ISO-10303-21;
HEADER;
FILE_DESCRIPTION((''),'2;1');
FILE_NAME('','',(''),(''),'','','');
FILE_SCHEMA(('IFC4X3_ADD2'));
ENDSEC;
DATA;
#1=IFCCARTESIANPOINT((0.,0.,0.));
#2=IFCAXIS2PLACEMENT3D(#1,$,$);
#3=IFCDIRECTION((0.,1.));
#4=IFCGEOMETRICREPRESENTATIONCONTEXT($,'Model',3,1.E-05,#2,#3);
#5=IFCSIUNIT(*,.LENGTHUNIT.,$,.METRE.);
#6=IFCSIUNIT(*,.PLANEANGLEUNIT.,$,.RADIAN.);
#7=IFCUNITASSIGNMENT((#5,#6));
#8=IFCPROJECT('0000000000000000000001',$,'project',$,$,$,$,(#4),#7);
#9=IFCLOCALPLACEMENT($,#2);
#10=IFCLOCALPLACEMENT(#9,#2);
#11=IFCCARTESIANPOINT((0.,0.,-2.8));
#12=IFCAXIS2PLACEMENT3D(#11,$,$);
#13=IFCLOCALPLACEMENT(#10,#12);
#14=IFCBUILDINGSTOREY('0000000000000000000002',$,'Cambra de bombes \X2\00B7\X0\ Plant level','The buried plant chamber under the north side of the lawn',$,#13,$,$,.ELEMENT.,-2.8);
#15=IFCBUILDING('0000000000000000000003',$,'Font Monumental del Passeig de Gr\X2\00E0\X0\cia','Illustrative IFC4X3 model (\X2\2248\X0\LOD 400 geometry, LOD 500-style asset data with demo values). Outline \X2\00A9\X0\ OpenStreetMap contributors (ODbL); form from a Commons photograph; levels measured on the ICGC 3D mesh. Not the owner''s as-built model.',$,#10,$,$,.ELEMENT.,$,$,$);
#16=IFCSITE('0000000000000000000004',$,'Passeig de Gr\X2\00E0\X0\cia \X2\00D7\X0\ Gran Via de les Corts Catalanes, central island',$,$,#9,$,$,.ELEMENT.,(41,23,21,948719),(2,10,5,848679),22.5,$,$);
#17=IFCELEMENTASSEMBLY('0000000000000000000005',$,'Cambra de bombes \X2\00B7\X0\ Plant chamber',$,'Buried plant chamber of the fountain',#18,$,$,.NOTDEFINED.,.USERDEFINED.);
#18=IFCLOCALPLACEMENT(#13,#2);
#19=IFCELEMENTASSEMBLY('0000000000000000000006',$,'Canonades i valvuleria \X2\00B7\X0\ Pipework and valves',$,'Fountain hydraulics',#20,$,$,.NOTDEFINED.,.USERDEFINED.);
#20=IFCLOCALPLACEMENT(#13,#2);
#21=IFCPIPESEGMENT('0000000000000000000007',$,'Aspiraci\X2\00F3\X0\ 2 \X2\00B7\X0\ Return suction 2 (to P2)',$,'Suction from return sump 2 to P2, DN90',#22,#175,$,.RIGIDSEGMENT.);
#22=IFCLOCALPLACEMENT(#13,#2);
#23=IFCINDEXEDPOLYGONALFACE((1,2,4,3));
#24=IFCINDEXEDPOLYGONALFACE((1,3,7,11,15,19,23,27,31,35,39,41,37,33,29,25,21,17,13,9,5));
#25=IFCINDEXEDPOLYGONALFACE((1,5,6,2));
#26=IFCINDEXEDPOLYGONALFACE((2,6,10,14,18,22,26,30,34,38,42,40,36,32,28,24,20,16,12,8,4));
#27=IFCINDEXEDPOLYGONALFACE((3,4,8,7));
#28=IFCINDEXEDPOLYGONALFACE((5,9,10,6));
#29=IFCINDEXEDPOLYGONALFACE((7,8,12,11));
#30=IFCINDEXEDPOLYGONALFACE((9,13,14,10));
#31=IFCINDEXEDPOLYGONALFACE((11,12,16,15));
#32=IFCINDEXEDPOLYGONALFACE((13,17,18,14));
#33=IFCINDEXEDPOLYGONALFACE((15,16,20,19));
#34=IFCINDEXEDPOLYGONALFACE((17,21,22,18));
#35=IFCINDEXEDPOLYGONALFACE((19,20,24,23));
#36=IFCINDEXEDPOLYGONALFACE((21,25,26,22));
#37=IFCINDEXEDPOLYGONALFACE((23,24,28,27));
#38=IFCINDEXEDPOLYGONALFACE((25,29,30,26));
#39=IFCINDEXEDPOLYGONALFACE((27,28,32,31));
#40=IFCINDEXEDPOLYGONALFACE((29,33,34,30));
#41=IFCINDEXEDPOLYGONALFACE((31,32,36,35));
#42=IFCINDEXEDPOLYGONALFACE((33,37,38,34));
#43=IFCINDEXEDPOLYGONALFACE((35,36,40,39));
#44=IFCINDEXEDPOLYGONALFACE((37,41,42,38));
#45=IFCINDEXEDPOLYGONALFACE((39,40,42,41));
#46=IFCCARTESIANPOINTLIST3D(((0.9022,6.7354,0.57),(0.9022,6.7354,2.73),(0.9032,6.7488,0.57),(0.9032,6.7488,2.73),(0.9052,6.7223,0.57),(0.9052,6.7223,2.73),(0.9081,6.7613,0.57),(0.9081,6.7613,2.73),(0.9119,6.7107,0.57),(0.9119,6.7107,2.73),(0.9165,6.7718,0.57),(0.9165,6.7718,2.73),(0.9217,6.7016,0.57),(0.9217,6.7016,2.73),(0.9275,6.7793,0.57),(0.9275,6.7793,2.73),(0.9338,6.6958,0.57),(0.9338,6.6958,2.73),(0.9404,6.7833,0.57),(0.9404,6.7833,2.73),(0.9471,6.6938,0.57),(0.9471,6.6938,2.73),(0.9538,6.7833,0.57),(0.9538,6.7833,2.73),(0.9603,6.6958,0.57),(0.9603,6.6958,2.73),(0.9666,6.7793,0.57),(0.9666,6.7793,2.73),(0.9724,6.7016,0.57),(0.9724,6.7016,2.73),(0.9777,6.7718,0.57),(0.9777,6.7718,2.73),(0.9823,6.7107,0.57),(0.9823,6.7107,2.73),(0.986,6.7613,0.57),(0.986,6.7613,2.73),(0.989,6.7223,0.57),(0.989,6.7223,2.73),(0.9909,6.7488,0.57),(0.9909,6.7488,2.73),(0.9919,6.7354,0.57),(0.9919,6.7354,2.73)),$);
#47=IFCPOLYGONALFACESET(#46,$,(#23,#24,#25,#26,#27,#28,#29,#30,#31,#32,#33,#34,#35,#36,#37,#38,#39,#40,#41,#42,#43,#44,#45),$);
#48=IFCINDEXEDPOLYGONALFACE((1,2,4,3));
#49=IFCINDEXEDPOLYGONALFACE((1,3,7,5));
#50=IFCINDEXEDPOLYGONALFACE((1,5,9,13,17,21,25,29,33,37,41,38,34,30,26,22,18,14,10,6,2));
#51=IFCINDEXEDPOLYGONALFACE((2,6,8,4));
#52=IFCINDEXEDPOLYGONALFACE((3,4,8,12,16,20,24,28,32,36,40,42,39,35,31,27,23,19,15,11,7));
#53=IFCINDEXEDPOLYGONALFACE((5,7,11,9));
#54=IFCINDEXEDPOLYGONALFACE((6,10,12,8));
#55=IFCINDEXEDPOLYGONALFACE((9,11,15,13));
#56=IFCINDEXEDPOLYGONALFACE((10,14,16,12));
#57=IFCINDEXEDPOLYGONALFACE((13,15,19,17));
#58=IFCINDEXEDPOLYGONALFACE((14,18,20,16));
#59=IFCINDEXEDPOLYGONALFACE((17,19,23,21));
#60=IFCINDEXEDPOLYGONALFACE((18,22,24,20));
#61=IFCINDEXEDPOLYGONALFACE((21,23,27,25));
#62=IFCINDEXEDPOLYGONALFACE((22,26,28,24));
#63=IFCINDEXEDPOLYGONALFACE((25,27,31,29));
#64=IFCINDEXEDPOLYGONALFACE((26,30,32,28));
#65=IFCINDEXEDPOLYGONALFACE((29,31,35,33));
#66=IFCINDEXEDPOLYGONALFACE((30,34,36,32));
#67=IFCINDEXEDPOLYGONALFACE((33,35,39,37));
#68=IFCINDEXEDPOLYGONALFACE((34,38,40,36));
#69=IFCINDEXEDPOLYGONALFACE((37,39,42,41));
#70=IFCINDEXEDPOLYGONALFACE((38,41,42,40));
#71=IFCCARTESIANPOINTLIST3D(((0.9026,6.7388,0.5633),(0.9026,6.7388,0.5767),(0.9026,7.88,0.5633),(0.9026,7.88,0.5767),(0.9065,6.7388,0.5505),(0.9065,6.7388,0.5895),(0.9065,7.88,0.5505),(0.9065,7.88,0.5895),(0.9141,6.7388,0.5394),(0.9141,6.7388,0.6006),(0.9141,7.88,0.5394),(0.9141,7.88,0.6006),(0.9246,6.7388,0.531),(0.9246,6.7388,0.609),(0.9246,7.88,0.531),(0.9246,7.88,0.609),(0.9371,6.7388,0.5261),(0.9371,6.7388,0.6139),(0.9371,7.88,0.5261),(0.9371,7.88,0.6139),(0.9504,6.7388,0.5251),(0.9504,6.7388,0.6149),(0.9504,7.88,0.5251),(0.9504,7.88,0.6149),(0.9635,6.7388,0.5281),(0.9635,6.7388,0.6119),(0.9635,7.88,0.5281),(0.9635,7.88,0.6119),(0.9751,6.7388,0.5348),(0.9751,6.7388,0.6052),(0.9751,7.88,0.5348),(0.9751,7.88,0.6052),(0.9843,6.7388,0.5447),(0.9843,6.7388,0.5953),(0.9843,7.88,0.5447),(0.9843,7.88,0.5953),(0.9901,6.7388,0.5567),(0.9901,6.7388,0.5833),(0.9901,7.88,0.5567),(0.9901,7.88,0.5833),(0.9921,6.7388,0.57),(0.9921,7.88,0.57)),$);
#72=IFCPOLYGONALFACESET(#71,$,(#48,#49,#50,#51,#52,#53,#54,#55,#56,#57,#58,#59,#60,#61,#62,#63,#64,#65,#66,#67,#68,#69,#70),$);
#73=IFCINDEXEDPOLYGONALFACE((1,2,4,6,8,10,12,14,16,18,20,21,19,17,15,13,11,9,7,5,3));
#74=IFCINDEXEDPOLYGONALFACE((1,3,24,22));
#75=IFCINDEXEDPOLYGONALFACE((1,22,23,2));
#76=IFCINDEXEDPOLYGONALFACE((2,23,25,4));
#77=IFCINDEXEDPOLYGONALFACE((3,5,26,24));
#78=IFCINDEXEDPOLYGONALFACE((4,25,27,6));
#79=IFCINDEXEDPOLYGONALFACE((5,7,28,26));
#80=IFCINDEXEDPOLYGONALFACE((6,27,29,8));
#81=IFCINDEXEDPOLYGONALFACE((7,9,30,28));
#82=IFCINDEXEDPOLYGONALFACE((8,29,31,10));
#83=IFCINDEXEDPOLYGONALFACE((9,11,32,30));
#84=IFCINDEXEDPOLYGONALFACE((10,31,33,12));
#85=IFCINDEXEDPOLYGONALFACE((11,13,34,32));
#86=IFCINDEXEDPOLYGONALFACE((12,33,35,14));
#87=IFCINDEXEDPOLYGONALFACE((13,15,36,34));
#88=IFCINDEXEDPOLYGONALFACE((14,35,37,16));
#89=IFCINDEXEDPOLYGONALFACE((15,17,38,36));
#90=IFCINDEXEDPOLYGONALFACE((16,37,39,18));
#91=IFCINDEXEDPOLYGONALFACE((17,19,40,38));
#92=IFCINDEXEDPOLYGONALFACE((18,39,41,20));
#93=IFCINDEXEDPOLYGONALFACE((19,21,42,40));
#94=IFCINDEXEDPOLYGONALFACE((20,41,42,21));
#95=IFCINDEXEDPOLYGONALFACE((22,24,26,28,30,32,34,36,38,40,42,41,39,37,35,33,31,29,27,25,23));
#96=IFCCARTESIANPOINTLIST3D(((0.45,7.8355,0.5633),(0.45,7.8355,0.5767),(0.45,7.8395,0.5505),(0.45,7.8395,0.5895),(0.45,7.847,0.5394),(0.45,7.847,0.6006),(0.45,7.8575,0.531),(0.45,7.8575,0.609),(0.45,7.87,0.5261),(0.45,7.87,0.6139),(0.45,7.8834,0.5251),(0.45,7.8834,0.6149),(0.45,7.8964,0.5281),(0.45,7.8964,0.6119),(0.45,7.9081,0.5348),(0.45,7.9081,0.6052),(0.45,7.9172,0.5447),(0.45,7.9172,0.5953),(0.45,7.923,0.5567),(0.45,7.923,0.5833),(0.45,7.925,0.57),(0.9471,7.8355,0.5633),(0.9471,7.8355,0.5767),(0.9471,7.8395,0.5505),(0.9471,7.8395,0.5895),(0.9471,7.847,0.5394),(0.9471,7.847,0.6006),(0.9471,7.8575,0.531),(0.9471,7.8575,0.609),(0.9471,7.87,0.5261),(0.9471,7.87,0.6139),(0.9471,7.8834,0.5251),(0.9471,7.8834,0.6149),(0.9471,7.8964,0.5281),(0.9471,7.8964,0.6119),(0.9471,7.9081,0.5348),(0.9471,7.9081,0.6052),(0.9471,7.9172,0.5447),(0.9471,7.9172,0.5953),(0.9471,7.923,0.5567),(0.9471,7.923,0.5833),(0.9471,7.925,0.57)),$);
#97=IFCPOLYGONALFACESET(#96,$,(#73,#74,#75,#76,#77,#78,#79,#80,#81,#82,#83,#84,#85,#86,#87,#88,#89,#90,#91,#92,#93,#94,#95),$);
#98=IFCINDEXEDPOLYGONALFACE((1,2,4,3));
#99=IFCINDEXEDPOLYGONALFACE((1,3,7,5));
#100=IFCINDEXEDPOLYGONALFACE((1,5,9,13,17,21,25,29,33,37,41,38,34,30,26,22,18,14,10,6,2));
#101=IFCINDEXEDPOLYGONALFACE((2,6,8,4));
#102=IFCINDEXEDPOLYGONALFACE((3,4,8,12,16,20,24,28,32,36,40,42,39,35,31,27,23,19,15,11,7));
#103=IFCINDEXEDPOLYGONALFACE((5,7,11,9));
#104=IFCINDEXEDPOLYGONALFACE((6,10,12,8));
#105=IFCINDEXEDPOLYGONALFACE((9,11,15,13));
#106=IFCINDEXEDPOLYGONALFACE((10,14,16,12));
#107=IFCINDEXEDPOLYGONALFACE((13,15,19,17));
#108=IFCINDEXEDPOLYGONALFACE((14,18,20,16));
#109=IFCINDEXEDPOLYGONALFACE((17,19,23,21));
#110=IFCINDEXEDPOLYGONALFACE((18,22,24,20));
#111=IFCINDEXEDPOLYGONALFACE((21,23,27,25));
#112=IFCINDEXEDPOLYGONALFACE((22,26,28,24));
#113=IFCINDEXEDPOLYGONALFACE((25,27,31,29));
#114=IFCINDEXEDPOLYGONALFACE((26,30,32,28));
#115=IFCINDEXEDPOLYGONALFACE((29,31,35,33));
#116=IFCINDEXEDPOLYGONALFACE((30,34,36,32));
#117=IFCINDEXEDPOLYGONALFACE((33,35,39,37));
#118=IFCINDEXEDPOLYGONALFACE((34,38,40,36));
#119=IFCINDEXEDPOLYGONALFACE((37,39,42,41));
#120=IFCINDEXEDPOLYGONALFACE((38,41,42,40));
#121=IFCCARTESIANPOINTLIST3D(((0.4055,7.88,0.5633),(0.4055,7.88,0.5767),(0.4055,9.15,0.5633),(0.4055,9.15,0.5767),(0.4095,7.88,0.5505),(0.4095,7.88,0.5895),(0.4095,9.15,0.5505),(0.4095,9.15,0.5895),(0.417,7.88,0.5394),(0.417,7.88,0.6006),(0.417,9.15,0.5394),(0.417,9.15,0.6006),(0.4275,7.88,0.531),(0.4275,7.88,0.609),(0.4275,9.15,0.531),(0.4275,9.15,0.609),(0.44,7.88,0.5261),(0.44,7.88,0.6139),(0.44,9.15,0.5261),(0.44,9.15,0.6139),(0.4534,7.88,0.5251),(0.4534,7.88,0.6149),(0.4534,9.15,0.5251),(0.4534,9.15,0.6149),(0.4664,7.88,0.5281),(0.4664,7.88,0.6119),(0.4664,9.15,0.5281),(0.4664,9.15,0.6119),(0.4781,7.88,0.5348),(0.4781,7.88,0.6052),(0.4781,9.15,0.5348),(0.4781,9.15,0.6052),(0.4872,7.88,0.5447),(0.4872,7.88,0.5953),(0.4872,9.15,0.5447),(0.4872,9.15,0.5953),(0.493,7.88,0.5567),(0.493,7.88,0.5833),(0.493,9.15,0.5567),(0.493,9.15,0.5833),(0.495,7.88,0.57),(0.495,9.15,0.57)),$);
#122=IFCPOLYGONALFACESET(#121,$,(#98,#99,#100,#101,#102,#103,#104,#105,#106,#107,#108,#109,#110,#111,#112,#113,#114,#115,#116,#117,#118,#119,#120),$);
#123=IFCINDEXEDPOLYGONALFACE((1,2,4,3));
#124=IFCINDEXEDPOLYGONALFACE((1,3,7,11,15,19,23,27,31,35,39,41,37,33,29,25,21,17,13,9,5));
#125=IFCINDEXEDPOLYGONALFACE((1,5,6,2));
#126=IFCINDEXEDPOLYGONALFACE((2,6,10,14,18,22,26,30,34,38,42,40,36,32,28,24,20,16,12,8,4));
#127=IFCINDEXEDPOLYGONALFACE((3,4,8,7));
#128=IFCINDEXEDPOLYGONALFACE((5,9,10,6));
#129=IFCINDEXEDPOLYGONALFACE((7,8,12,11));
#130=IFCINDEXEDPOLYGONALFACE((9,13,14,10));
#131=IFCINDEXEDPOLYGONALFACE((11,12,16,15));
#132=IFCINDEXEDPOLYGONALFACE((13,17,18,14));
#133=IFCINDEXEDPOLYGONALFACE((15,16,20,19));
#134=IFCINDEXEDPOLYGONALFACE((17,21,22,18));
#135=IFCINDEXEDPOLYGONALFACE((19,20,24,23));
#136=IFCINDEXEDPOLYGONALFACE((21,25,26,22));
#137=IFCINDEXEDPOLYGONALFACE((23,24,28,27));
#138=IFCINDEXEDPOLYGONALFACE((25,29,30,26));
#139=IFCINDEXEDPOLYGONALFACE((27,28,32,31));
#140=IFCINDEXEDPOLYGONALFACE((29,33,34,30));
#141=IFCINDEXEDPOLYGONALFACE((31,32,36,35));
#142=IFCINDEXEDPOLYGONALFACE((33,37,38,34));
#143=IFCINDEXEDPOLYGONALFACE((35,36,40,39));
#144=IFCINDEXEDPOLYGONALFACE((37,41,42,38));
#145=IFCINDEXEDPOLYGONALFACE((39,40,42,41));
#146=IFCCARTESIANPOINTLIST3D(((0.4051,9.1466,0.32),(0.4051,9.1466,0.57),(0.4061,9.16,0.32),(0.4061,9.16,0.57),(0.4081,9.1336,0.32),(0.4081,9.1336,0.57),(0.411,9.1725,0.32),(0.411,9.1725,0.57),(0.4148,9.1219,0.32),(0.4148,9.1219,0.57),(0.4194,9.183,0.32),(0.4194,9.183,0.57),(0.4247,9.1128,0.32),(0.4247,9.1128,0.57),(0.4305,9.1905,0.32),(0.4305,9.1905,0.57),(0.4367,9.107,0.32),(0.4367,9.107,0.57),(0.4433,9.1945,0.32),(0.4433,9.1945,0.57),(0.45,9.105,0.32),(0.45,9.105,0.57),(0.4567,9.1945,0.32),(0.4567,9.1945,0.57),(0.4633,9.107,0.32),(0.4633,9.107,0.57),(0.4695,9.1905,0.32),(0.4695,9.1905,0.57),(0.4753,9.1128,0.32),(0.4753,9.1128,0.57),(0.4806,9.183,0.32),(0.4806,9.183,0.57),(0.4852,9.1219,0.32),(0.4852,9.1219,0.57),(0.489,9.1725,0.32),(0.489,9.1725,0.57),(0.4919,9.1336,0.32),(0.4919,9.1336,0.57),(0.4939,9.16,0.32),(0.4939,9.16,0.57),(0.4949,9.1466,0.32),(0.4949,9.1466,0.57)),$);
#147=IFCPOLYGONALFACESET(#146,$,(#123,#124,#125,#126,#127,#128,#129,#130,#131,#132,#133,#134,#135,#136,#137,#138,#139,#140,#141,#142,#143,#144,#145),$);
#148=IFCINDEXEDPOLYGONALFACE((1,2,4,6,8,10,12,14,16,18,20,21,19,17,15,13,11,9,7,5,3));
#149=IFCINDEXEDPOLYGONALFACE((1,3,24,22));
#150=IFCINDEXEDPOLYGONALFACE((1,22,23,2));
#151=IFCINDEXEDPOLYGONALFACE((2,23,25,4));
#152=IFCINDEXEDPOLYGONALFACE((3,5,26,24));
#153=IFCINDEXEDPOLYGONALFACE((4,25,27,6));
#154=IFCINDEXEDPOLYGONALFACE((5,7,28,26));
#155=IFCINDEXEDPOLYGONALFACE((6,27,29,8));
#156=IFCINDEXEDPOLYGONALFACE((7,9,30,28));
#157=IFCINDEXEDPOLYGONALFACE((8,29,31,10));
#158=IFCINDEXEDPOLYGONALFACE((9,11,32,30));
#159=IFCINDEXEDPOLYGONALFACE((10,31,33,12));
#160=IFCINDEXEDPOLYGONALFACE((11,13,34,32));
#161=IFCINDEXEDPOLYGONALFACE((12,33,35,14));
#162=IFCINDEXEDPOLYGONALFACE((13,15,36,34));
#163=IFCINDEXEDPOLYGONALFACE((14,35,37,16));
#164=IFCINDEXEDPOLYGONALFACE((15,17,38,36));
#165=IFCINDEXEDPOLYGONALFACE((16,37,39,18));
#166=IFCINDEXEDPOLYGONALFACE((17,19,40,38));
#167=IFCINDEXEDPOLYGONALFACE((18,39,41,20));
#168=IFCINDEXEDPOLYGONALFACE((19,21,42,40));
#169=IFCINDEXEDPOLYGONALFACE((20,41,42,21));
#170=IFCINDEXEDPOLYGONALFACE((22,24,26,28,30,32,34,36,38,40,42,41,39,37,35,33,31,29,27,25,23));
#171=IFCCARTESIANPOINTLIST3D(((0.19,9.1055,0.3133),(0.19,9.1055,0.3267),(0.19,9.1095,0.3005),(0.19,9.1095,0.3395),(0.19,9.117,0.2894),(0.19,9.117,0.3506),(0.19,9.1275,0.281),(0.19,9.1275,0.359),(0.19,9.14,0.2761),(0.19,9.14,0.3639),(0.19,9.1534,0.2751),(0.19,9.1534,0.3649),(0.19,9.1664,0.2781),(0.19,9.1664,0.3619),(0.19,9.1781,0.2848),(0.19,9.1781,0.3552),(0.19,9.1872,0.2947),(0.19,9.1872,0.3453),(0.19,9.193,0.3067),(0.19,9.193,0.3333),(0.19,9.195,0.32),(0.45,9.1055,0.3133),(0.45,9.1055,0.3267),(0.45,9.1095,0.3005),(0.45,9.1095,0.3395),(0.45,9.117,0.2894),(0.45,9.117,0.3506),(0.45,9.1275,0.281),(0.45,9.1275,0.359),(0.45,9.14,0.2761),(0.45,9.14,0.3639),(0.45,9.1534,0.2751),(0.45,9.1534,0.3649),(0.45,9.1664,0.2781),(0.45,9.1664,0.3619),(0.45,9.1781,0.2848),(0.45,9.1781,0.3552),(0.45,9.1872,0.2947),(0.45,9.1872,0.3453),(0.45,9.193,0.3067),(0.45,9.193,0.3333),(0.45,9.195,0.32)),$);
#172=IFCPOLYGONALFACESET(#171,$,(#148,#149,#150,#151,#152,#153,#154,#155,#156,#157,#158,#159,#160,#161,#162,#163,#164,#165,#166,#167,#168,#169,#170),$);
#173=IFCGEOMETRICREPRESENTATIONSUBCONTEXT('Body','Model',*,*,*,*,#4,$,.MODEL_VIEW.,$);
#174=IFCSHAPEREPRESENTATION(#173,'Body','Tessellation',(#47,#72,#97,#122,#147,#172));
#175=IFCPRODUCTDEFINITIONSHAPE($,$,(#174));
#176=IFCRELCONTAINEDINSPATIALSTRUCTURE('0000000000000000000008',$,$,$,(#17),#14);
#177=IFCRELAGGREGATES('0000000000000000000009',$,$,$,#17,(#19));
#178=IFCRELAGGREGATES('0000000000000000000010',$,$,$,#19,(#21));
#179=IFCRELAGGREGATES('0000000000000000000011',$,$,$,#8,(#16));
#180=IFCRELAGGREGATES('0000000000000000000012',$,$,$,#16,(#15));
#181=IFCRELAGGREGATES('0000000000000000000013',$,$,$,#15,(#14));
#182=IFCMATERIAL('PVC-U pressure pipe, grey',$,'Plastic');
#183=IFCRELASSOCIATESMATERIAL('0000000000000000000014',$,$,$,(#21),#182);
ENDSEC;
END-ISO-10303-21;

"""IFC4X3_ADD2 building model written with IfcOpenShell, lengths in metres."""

from ifc_helpers import new_model, si_unit, direction, frame, origin, origin_2d_with_axis, place, context, subcontext, project, spatial, circle, extrude, material, element, aggregate, save


model = new_model("IFC4X3_ADD2")

# Units and contexts
model_context = context("Model", 3, precision=1e-05, world=origin(), true_north=direction((0.0, 1.0)))
body_context = subcontext(model_context, "Body", "Model", "MODEL_VIEW")
ifc_project = project(units=[si_unit("LENGTHUNIT", "METRE"), si_unit("PLANEANGLEUNIT", "RADIAN")], contexts=[model_context])

# Site, building, storey
site_placement = place(None, origin())
site = spatial("IfcSite", under=ifc_project, at=site_placement, Name="Passeig de Gràcia × Gran Via de les Corts Catalanes, central island", CompositionType="ELEMENT", RefLatitude=(41, 23, 21, 948719), RefLongitude=(2, 10, 5, 848679), RefElevation=22.5)
building_placement = place(site_placement, origin())
building = spatial("IfcBuilding", under=site, at=building_placement, Name="Font Monumental del Passeig de Gràcia", Description="Illustrative IFC4X3 model (≈LOD 400 geometry, LOD 500-style asset data with demo values). Outline © OpenStreetMap contributors (ODbL); form from a Commons photograph; levels measured on the ICGC 3D mesh. Not the owner's as-built model.", CompositionType="ELEMENT")
storey_placement = place(building_placement, frame((0.0, 0.0, -2.8)))
storey = spatial("IfcBuildingStorey", under=building, at=storey_placement, Name="Cambra de bombes · Plant level", Description="The buried plant chamber under the north side of the lawn", CompositionType="ELEMENT", Elevation=-2.8)

# Element assemblies, pipe segment
assembly_1_placement = place(building_placement, origin())
assembly_1 = element("IfcElementAssembly", 1, at=assembly_1_placement, inside=storey, Name="Cambra de bombes · Plant chamber", ObjectType="Buried plant chamber of the fountain", AssemblyPlace="NOTDEFINED", PredefinedType="USERDEFINED")
assembly_2_placement = place(building_placement, origin())
assembly_2 = element("IfcElementAssembly", 2, at=assembly_2_placement, Name="Canonades i valvuleria · Pipework and valves", ObjectType="Fountain hydraulics", AssemblyPlace="NOTDEFINED", PredefinedType="USERDEFINED")
aggregate(assembly_1, [assembly_2])
ifc_material_1 = material(Name="PVC-U pressure pipe, grey", Category="Plastic")
pipe_segment_1_placement = place(building_placement, origin())
pipe_segment_1 = element("IfcPipeSegment", 3, at=pipe_segment_1_placement, material=ifc_material_1, Name="Aspiració 2 · Return suction 2 (to P2)", ObjectType="Suction from return sump 2 to P2, DN90", PredefinedType="RIGIDSEGMENT", context=body_context, shape_type="SweptSolid", body=[
    extrude(circle(Radius=0.045, at=origin_2d_with_axis()), frame((0.9471, 6.7388, -0.07), z_axis=(0.0, 0.0, -1.0), x_axis=(0.0, -1.0, 0.0)), (0.0, 0.0, 1.0), 2.16),
    extrude(circle(Radius=0.045, at=origin_2d_with_axis()), frame((0.9471, 6.7388, -2.23), z_axis=(0.0, 1.0, 0.0), x_axis=(1.0, 0.0, 0.0)), (0.0, 0.0, 1.0), 1.1412),
    extrude(circle(Radius=0.045, at=origin_2d_with_axis()), frame((0.9471, 7.88, -2.23), z_axis=(-1.0, 0.0, 0.0), x_axis=(0.0, 1.0, 0.0)), (0.0, 0.0, 1.0), 0.4971),
    extrude(circle(Radius=0.045, at=origin_2d_with_axis()), frame((0.45, 7.88, -2.23), z_axis=(0.0, 1.0, 0.0), x_axis=(1.0, 0.0, 0.0)), (0.0, 0.0, 1.0), 1.27),
    extrude(circle(Radius=0.045, at=origin_2d_with_axis()), frame((0.45, 9.15, -2.23), z_axis=(0.0, 0.0, -1.0), x_axis=(0.0, -1.0, 0.0)), (0.0, 0.0, 1.0), 0.25),
    extrude(circle(Radius=0.045, at=origin_2d_with_axis()), frame((0.45, 9.15, -2.48), z_axis=(-1.0, 0.0, 0.0), x_axis=(0.0, 1.0, 0.0)), (0.0, 0.0, 1.0), 0.26),
])
aggregate(assembly_2, [pipe_segment_1])

save(model, "model.ifc")
